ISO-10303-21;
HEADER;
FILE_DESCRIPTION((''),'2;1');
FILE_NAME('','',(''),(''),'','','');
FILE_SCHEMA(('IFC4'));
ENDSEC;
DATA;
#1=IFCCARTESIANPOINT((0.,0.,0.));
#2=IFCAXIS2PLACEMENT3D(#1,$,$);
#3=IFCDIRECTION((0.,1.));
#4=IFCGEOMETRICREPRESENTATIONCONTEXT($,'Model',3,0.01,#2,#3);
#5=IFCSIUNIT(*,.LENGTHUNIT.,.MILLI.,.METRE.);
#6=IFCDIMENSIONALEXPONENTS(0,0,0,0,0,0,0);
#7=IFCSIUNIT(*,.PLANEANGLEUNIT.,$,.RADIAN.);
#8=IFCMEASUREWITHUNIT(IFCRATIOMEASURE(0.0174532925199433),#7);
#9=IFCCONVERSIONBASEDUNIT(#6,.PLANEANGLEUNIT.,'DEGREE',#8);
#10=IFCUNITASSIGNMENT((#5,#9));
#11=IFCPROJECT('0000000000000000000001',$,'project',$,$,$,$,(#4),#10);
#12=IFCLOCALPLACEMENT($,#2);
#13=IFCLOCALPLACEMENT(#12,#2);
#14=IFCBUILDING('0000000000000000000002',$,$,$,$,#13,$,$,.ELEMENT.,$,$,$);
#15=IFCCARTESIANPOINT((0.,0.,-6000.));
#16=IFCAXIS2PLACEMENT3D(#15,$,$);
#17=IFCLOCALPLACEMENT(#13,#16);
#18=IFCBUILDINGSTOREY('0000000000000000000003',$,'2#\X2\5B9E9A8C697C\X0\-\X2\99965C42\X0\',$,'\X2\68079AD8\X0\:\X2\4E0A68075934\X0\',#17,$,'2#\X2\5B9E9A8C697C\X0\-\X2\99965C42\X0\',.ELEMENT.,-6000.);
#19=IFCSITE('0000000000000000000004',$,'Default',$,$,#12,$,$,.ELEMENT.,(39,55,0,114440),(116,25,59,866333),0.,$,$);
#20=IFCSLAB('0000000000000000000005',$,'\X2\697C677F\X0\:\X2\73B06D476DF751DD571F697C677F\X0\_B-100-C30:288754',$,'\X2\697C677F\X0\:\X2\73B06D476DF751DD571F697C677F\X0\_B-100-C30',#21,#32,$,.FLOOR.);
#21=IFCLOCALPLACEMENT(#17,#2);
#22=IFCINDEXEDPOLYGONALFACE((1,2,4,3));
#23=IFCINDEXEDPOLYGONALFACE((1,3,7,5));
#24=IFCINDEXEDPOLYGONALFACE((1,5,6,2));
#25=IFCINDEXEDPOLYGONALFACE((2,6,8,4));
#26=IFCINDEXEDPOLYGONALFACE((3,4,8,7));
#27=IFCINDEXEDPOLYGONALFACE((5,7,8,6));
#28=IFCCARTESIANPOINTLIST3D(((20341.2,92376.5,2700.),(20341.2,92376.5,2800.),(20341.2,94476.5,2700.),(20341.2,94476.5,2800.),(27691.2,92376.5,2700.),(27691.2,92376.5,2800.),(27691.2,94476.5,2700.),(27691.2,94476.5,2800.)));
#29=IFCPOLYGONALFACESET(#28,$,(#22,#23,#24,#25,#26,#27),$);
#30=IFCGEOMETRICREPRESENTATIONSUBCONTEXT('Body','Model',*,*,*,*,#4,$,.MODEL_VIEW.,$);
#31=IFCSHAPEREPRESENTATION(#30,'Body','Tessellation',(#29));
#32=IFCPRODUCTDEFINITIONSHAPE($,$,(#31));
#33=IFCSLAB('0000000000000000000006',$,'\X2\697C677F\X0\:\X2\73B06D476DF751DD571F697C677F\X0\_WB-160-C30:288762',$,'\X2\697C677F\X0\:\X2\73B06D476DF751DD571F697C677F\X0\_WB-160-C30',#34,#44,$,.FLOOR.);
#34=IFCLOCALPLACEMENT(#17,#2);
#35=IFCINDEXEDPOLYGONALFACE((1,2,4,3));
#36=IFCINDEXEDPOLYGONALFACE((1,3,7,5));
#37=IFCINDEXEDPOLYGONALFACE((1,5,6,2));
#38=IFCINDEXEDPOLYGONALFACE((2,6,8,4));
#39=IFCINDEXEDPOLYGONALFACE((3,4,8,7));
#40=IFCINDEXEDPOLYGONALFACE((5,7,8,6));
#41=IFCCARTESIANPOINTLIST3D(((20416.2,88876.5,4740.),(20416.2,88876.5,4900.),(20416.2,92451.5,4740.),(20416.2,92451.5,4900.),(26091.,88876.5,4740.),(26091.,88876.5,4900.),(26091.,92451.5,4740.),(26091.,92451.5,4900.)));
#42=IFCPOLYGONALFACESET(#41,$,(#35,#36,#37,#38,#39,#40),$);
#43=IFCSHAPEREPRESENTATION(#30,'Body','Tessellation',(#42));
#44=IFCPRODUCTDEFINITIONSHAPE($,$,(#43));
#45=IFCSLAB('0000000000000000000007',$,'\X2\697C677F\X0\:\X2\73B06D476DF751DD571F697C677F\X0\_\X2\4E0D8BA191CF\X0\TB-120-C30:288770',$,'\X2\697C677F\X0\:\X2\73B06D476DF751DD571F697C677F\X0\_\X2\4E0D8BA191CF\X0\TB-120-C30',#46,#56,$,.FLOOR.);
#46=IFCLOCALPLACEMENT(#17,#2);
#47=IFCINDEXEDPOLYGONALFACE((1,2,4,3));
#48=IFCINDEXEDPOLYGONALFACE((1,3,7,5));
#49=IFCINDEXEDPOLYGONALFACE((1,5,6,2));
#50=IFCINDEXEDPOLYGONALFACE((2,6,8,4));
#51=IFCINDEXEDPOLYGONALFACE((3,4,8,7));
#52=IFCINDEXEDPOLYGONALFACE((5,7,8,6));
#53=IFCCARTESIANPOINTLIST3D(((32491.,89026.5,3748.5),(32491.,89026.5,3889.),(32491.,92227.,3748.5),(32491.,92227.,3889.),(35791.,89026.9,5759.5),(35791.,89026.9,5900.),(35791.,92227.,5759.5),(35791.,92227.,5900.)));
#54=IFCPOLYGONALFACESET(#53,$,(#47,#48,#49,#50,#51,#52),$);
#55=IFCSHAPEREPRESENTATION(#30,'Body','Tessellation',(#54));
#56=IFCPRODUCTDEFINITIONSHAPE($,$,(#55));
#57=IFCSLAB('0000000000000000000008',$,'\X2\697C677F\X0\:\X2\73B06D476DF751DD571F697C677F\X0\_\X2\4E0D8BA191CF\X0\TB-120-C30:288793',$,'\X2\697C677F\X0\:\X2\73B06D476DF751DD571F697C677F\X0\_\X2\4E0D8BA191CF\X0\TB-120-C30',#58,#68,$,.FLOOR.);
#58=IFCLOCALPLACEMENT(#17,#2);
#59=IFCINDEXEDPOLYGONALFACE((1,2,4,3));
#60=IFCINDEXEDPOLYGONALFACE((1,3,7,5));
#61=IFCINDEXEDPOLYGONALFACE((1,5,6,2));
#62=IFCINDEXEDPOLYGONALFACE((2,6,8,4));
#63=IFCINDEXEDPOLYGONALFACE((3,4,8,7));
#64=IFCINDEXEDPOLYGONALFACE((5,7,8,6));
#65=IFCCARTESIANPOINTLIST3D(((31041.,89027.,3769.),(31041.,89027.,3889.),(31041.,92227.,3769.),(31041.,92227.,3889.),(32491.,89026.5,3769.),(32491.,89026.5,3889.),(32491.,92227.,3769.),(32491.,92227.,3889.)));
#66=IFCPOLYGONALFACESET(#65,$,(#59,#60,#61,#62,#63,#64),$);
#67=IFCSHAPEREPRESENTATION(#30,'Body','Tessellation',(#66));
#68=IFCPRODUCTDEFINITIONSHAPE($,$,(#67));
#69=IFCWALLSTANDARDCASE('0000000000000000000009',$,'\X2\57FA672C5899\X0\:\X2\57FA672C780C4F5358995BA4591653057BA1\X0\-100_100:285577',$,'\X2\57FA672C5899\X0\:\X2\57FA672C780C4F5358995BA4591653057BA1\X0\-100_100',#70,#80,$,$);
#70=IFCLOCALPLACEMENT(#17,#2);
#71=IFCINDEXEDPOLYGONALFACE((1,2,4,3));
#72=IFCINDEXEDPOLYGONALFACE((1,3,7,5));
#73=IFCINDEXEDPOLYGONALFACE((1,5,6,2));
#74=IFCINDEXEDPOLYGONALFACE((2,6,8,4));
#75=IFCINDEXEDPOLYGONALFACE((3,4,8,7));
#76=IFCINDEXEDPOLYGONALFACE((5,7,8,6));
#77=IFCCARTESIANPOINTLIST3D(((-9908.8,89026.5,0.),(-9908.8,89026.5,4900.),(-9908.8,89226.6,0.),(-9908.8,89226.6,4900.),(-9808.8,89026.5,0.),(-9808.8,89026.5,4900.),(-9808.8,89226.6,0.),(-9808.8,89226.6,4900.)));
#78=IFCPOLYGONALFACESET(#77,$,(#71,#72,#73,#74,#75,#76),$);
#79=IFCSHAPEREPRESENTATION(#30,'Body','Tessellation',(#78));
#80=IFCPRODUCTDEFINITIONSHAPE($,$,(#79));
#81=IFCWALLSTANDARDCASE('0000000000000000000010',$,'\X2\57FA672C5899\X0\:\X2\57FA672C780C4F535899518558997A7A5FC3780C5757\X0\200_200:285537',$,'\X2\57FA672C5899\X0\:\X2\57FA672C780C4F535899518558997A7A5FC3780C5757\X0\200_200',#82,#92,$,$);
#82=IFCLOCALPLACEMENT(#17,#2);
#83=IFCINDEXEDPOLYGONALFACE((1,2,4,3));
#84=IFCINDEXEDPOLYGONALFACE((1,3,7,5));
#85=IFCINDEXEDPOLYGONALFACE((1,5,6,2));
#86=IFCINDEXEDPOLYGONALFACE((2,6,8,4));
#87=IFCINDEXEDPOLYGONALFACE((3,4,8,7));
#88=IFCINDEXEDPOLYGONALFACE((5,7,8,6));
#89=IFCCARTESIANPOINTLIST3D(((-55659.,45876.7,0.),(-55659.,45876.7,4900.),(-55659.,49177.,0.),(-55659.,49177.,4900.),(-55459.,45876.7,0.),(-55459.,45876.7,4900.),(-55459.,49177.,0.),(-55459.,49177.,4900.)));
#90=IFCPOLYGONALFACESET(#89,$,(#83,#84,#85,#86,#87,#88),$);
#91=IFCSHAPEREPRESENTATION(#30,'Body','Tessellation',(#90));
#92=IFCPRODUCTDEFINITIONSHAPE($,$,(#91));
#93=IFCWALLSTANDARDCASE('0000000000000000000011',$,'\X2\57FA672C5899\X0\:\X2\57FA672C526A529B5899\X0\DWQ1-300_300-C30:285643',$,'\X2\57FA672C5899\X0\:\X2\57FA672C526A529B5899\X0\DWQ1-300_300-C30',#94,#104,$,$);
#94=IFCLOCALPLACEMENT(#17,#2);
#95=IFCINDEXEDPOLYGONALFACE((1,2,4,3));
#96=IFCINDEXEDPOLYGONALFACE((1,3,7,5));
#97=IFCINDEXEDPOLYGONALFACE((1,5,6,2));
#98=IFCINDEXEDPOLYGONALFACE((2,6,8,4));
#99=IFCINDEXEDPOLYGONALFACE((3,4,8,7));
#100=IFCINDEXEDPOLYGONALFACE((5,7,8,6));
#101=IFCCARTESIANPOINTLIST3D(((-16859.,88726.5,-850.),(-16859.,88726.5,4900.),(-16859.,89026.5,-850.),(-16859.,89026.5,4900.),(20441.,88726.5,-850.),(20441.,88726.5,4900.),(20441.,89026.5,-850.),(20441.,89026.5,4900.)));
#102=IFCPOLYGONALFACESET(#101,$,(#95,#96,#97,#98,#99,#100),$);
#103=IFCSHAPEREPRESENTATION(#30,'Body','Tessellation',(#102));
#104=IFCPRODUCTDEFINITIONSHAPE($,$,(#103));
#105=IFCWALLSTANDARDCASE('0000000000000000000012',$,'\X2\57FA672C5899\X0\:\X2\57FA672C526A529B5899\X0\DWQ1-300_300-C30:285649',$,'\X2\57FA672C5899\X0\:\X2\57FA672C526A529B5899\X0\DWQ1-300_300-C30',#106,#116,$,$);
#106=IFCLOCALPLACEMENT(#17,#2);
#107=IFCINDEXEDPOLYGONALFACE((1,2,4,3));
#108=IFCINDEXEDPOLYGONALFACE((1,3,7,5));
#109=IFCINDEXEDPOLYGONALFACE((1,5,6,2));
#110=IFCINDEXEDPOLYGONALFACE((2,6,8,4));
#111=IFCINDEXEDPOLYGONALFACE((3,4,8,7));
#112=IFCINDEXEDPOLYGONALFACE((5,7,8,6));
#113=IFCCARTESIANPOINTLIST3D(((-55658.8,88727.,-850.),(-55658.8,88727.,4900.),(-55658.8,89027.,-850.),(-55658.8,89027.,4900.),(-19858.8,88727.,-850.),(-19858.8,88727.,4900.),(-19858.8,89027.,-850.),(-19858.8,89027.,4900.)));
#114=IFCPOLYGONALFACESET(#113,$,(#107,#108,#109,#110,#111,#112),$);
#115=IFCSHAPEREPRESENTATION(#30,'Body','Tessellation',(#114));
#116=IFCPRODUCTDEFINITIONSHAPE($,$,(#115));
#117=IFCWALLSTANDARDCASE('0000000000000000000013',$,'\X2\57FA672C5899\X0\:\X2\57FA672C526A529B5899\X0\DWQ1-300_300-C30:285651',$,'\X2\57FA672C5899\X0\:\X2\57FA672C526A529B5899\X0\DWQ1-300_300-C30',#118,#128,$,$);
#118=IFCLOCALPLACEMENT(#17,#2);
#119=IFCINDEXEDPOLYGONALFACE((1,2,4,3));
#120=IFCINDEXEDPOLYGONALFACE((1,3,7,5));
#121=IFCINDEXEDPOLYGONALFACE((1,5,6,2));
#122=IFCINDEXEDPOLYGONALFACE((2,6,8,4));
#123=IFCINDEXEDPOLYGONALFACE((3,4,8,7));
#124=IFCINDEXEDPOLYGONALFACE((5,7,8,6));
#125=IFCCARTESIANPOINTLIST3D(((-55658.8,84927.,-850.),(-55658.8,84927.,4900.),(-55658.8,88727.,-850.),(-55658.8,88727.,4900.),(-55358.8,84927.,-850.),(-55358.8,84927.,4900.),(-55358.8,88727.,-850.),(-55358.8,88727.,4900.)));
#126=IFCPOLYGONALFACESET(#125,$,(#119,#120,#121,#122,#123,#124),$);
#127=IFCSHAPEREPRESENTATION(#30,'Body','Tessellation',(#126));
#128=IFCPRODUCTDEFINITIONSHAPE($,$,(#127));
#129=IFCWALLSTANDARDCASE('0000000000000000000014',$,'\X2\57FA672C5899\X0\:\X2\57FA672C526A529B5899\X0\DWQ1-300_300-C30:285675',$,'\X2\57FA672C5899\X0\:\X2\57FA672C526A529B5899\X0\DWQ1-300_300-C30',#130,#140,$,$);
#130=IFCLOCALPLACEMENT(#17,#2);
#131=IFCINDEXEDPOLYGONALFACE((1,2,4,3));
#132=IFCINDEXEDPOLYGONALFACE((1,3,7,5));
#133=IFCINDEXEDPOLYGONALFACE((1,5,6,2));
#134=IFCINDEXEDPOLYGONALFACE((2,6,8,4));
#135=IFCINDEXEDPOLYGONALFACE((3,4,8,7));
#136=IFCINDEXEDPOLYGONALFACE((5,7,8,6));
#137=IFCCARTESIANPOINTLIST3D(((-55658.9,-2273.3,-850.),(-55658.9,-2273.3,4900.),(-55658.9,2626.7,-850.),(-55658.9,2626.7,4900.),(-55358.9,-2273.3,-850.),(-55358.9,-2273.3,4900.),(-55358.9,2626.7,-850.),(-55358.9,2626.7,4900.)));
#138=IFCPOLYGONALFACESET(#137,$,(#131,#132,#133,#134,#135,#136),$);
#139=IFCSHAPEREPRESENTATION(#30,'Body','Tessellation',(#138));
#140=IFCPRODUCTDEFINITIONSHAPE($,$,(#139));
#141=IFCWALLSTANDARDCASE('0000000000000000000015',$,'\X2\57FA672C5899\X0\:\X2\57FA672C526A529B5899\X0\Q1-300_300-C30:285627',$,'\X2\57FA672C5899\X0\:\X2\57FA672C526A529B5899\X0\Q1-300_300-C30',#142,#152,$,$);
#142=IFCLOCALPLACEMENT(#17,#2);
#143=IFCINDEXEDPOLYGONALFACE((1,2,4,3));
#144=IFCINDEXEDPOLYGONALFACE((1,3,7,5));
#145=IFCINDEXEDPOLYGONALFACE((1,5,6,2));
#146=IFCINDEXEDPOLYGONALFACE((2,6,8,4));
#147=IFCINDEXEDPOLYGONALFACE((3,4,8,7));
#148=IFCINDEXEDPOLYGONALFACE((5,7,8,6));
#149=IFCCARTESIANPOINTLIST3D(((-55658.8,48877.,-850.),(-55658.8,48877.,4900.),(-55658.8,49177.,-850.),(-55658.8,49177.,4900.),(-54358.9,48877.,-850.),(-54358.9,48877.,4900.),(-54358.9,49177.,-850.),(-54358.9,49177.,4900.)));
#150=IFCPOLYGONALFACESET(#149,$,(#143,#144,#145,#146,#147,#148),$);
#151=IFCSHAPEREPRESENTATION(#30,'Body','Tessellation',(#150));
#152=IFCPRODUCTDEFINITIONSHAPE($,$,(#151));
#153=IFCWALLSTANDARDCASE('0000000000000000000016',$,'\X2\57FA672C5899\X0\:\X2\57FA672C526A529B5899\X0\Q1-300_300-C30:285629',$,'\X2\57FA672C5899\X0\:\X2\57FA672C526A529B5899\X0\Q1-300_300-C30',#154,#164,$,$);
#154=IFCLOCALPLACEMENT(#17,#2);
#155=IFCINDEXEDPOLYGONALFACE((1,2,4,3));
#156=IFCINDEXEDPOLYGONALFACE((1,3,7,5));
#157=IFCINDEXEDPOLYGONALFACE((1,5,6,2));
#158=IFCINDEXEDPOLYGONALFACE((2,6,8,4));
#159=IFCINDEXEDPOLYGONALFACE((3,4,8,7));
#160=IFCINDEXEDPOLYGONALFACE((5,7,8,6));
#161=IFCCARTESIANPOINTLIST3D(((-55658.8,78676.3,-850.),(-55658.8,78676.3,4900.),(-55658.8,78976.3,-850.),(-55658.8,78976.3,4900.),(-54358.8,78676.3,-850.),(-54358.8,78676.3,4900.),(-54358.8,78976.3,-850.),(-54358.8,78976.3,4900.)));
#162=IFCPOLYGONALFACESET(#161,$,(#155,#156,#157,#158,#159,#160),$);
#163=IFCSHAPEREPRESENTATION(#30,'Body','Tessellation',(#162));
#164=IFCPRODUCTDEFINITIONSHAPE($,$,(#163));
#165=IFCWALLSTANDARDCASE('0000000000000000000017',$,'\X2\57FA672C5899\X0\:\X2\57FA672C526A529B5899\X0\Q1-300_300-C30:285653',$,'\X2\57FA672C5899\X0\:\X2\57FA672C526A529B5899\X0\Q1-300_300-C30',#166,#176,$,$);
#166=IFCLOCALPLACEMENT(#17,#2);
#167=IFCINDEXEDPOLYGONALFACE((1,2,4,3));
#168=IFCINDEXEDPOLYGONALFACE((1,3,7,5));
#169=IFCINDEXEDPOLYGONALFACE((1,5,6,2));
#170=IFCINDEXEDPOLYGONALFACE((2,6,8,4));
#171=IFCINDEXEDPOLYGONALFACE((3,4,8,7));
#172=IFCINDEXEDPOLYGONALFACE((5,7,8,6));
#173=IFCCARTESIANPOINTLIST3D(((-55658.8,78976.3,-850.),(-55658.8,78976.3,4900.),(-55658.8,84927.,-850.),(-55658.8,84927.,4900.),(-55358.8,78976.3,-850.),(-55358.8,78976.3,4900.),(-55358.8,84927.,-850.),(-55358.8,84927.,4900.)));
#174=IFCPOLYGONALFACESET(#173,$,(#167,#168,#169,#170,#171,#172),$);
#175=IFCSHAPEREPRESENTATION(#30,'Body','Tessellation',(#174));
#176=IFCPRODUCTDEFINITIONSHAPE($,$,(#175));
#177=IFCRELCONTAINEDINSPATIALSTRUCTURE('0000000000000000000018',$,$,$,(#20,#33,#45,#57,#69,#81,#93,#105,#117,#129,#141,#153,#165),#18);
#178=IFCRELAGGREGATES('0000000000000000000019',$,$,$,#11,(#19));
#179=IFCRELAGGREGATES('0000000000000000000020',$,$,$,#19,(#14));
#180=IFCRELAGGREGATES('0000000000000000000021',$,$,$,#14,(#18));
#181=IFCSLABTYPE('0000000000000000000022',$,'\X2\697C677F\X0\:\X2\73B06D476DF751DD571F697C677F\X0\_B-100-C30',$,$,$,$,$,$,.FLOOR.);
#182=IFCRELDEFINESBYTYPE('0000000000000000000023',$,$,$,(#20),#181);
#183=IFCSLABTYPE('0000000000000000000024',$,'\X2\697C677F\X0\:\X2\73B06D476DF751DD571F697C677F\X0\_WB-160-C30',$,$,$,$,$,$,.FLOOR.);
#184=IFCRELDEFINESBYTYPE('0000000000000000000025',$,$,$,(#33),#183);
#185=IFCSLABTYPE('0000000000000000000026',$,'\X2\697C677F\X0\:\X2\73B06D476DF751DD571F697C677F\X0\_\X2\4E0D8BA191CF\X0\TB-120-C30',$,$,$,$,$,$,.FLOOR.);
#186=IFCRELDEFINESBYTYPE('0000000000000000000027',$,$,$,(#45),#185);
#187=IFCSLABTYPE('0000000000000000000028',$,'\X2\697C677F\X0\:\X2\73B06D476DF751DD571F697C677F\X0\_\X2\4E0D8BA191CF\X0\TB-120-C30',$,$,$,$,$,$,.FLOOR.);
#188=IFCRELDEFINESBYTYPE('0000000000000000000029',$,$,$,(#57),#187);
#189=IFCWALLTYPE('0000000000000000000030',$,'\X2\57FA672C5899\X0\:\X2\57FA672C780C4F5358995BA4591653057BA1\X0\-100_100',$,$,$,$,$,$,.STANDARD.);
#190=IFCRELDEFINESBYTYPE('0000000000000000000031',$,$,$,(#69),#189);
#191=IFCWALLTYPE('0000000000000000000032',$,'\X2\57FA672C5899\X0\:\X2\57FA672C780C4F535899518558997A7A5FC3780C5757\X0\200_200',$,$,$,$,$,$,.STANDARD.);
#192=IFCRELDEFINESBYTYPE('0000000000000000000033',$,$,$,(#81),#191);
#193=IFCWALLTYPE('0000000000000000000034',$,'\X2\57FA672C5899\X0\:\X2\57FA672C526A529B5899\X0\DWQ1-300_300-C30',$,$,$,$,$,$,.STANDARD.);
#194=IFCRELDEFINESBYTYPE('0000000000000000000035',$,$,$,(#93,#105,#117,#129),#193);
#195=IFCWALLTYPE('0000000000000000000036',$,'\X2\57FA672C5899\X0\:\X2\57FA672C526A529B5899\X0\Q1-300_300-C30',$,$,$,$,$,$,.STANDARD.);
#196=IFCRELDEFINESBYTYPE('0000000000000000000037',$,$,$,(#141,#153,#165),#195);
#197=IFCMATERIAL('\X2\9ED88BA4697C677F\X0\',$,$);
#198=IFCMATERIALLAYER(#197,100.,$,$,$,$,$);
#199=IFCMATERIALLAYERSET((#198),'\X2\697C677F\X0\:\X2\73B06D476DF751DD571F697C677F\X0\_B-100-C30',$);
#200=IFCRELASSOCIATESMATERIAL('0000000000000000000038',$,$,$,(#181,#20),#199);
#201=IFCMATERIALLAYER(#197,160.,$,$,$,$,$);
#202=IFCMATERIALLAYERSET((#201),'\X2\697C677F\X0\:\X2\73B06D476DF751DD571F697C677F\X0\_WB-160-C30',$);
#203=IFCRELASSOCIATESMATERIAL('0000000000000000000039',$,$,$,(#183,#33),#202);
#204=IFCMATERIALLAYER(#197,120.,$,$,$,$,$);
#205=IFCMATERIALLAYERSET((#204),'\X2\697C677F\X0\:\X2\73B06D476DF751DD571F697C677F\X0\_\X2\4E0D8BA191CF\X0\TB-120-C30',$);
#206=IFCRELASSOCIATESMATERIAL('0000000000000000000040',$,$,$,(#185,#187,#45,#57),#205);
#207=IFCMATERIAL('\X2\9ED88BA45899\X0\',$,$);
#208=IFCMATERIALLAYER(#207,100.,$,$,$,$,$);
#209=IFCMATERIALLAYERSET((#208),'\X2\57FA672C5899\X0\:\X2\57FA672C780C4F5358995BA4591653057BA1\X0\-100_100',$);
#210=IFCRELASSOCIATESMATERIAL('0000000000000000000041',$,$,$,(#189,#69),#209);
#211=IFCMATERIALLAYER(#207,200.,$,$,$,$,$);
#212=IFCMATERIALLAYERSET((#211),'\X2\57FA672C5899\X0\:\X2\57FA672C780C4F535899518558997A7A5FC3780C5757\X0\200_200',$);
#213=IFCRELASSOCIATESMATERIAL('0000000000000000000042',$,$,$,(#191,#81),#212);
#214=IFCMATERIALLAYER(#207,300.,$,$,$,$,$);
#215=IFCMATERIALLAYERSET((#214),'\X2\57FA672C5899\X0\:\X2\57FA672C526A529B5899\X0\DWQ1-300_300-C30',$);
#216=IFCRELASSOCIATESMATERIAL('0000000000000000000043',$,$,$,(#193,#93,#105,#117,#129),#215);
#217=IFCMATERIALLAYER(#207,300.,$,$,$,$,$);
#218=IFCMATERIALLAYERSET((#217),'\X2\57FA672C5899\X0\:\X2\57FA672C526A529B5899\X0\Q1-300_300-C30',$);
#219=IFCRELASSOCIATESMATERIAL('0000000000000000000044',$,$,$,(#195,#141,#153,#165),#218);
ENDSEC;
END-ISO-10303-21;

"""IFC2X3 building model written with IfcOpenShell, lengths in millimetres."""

from ifc_helpers import new_model, entity, si_unit, converted_unit, direction, frame, frame_2d, origin, place, context, subcontext, project, spatial, polyline, rectangle, outline, extrude, clip, halfspace, material, layer, layer_set, layer_usage, type_object, element, save


model = new_model("IFC2X3")

# Units and contexts
model_context = context("Model", 3, precision=0.01, world=origin(), true_north=direction((0.0, 1.0)))
body_context = subcontext(model_context, "Body", "Model", "MODEL_VIEW")
ifc_project = project(units=[si_unit("LENGTHUNIT", "METRE", prefix="MILLI"), converted_unit("PLANEANGLEUNIT", "DEGREE", entity("IfcRatioMeasure", 0.0174532925199433), si_unit("PLANEANGLEUNIT", "RADIAN"), dimensions=[0, 0, 0, 0, 0, 0, 0])], contexts=[model_context])

# Site, building, storey
site_placement = place(None, origin())
site = spatial("IfcSite", under=ifc_project, at=site_placement, Name="Default", CompositionType="ELEMENT", RefLatitude=(39, 55, 0, 114440), RefLongitude=(116, 25, 59, 866333), RefElevation=0.0)
building_placement = place(site_placement, origin())
building = spatial("IfcBuilding", under=site, at=building_placement, CompositionType="ELEMENT")
storey_placement = place(building_placement, frame((0.0, 0.0, -6000.0)))
storey = spatial("IfcBuildingStorey", under=building, at=storey_placement, Name="2#实验楼-首层", ObjectType="标高:上标头", LongName="2#实验楼-首层", CompositionType="ELEMENT", Elevation=-6000.0)

# Slabs
ifc_material_1 = material(Name="默认楼板")
ifc_layer_1 = layer(ifc_material_1, 100.0)
ifc_layer_set_1 = layer_set([ifc_layer_1], Name="楼板:现浇混凝土楼板_B-100-C30")
ifc_layer_usage_1 = layer_usage(ifc_layer_set_1, "AXIS3", "POSITIVE", 0.0)
slab_type_1 = type_object("IfcSlabType", Name="楼板:现浇混凝土楼板_B-100-C30", PredefinedType="FLOOR", material=ifc_layer_set_1)
slab_1_placement = place(storey_placement, origin())
element("IfcSlab", 1, at=slab_1_placement, inside=storey, type_object=slab_type_1, material=ifc_layer_usage_1, Name="楼板:现浇混凝土楼板_B-100-C30:288754", ObjectType="楼板:现浇混凝土楼板_B-100-C30", PredefinedType="FLOOR", context=body_context, shape_type="SweptSolid", body=[
    extrude(outline(polyline([(-3675.0, -1050.0), (3675.0, -1050.0), (3675.0, 1050.0), (-3675.0, 1050.0), (-3675.0, -1050.0)])), frame((24016.2, 93426.5, 2800.0), z_axis=(0.0, 0.0, -1.0), x_axis=(1.0, -0.000002, 0.0)), (0.0, 0.0, 1.0), 100.0),
])
ifc_layer_2 = layer(ifc_material_1, 160.0)
ifc_layer_set_2 = layer_set([ifc_layer_2], Name="楼板:现浇混凝土楼板_WB-160-C30")
ifc_layer_usage_2 = layer_usage(ifc_layer_set_2, "AXIS3", "POSITIVE", 0.0)
slab_type_2 = type_object("IfcSlabType", Name="楼板:现浇混凝土楼板_WB-160-C30", PredefinedType="FLOOR", material=ifc_layer_set_2)
slab_2_placement = place(storey_placement, origin())
element("IfcSlab", 2, at=slab_2_placement, inside=storey, type_object=slab_type_2, material=ifc_layer_usage_2, Name="楼板:现浇混凝土楼板_WB-160-C30:288762", ObjectType="楼板:现浇混凝土楼板_WB-160-C30", PredefinedType="FLOOR", context=body_context, shape_type="SweptSolid", body=[
    extrude(outline(polyline([(-1787.5, -2837.4), (1787.5, -2837.4), (1787.5, 2837.4), (-1787.5, 2837.4), (-1787.5, -2837.4)])), frame((23253.6, 90664.0, 4900.0), z_axis=(0.0, 0.0, -1.0), x_axis=(0.0, -1.0, 0.0)), (0.0, 0.0, 1.0), 160.0),
])
ifc_layer_3 = layer(ifc_material_1, 120.0)
ifc_layer_set_3 = layer_set([ifc_layer_3], Name="楼板:现浇混凝土楼板_不计量TB-120-C30")
ifc_layer_usage_3 = layer_usage(ifc_layer_set_3, "AXIS3", "POSITIVE", 0.0)
slab_type_3 = type_object("IfcSlabType", Name="楼板:现浇混凝土楼板_不计量TB-120-C30", PredefinedType="FLOOR", material=ifc_layer_set_3)
slab_3_placement = place(storey_placement, origin())
element("IfcSlab", 3, at=slab_3_placement, inside=storey, type_object=slab_type_3, material=ifc_layer_usage_3, Name="楼板:现浇混凝土楼板_不计量TB-120-C30:288770", ObjectType="楼板:现浇混凝土楼板_不计量TB-120-C30", PredefinedType="FLOOR", context=body_context, shape_type="Clipping", body=[
    clip(clip(extrude(outline(polyline([(-1600.3, -1932.2), (1600.1, -1932.2), (1600.1, 1932.2), (-1599.9, 1932.2), (-1600.3, -1932.2)])), frame((34141.0, 90626.9, 4894.5), z_axis=(0.520382, 0.0, -0.853934), x_axis=(0.0, 1.0, 0.0)), (0.0, -0.520382, 0.853934), 164.6), halfspace(frame((32491.0, 92227.0, 3748.5), z_axis=(0.520382, 0.0, -0.853934), x_axis=(0.853934, 0.0, 0.520382)), False)), halfspace(frame((32491.0, 92227.0, 3889.0), z_axis=(-0.520382, 0.0, 0.853934), x_axis=(-0.853934, 0.0, -0.520382)), False)),
])
ifc_layer_usage_4 = layer_usage(ifc_layer_set_3, "AXIS3", "POSITIVE", 0.0)
slab_type_4 = type_object("IfcSlabType", Name="楼板:现浇混凝土楼板_不计量TB-120-C30", PredefinedType="FLOOR", material=ifc_layer_set_3)
slab_4_placement = place(storey_placement, origin())
element("IfcSlab", 4, at=slab_4_placement, inside=storey, type_object=slab_type_4, material=ifc_layer_usage_4, Name="楼板:现浇混凝土楼板_不计量TB-120-C30:288793", ObjectType="楼板:现浇混凝土楼板_不计量TB-120-C30", PredefinedType="FLOOR", context=body_context, shape_type="SweptSolid", body=[
    extrude(outline(polyline([(-1599.9, -725.0), (1600.1, -725.0), (1600.1, 725.0), (-1600.3, 725.0), (-1599.9, -725.0)])), frame((31766.0, 90626.9, 3889.0), z_axis=(0.0, 0.0, -1.0), x_axis=(0.0, 1.0, 0.0)), (0.0, 0.0, 1.0), 120.0),
])

# Walls
ifc_material_2 = material(Name="默认墙")
ifc_layer_4 = layer(ifc_material_2, 100.0)
ifc_layer_set_4 = layer_set([ifc_layer_4], Name="基本墙:基本砌体墙室外包管-100_100")
ifc_layer_usage_5 = layer_usage(ifc_layer_set_4, "AXIS2", "NEGATIVE", 50.0)
wall_type_1 = type_object("IfcWallType", Name="基本墙:基本砌体墙室外包管-100_100", PredefinedType="STANDARD", material=ifc_layer_set_4)
wall_1_placement = place(storey_placement, frame((-9858.8, 89026.5, 0.0), z_axis=(0.0, 0.0, 1.0), x_axis=(0.0, 1.0, 0.0)))
element("IfcWallStandardCase", 5, at=wall_1_placement, inside=storey, type_object=wall_type_1, material=ifc_layer_usage_5, Name="基本墙:基本砌体墙室外包管-100_100:285577", ObjectType="基本墙:基本砌体墙室外包管-100_100", context=body_context, shape_type="SweptSolid", body=[
    extrude(rectangle(XDim=200.0, YDim=100.0, at=frame_2d((100.0, 0.0), x_axis=(-1.0, 0.0))), origin(), (0.0, 0.0, 1.0), 4900.0),
])
ifc_layer_5 = layer(ifc_material_2, 200.0)
ifc_layer_set_5 = layer_set([ifc_layer_5], Name="基本墙:基本砌体墙内墙空心砌块200_200")
ifc_layer_usage_6 = layer_usage(ifc_layer_set_5, "AXIS2", "NEGATIVE", 100.0)
wall_type_2 = type_object("IfcWallType", Name="基本墙:基本砌体墙内墙空心砌块200_200", PredefinedType="STANDARD", material=ifc_layer_set_5)
wall_2_placement = place(storey_placement, frame((-55559.0, 45876.7, 0.0), z_axis=(0.0, 0.0, 1.0), x_axis=(0.0, 1.0, 0.0)))
element("IfcWallStandardCase", 6, at=wall_2_placement, inside=storey, type_object=wall_type_2, material=ifc_layer_usage_6, Name="基本墙:基本砌体墙内墙空心砌块200_200:285537", ObjectType="基本墙:基本砌体墙内墙空心砌块200_200", context=body_context, shape_type="SweptSolid", body=[
    extrude(rectangle(XDim=3300.3, YDim=200.0, at=frame_2d((1650.2, 0.0), x_axis=(-1.0, 0.0))), origin(), (0.0, 0.0, 1.0), 4900.0),
])
ifc_layer_6 = layer(ifc_material_2, 300.0)
ifc_layer_set_6 = layer_set([ifc_layer_6], Name="基本墙:基本剪力墙DWQ1-300_300-C30")
ifc_layer_usage_7 = layer_usage(ifc_layer_set_6, "AXIS2", "NEGATIVE", 150.0)
wall_type_3 = type_object("IfcWallType", Name="基本墙:基本剪力墙DWQ1-300_300-C30", PredefinedType="STANDARD", material=ifc_layer_set_6)
wall_3_placement = place(storey_placement, frame((-16859.0, 88876.5, -850.0)))
element("IfcWallStandardCase", 7, at=wall_3_placement, inside=storey, type_object=wall_type_3, material=ifc_layer_usage_7, Name="基本墙:基本剪力墙DWQ1-300_300-C30:285643", ObjectType="基本墙:基本剪力墙DWQ1-300_300-C30", context=body_context, shape_type="SweptSolid", body=[
    extrude(rectangle(XDim=37300.0, YDim=300.0, at=frame_2d((18650.0, 0.0), x_axis=(-1.0, 0.0))), origin(), (0.0, 0.0, 1.0), 5750.0),
])
ifc_layer_usage_8 = layer_usage(ifc_layer_set_6, "AXIS2", "NEGATIVE", 150.0)
wall_4_placement = place(storey_placement, frame((-55658.8, 88877.0, -850.0)))
element("IfcWallStandardCase", 8, at=wall_4_placement, inside=storey, type_object=wall_type_3, material=ifc_layer_usage_8, Name="基本墙:基本剪力墙DWQ1-300_300-C30:285649", ObjectType="基本墙:基本剪力墙DWQ1-300_300-C30", context=body_context, shape_type="SweptSolid", body=[
    extrude(rectangle(XDim=35800.0, YDim=300.0, at=frame_2d((17900.0, 0.0), x_axis=(-1.0, 0.0))), origin(), (0.0, 0.0, 1.0), 5750.0),
])
ifc_layer_usage_9 = layer_usage(ifc_layer_set_6, "AXIS2", "NEGATIVE", 150.0)
wall_5_placement = place(storey_placement, frame((-55508.8, 84927.0, -850.0), z_axis=(0.0, 0.0, 1.0), x_axis=(0.0, 1.0, 0.0)))
element("IfcWallStandardCase", 9, at=wall_5_placement, inside=storey, type_object=wall_type_3, material=ifc_layer_usage_9, Name="基本墙:基本剪力墙DWQ1-300_300-C30:285651", ObjectType="基本墙:基本剪力墙DWQ1-300_300-C30", context=body_context, shape_type="SweptSolid", body=[
    extrude(rectangle(XDim=3800.0, YDim=300.0, at=frame_2d((1900.0, 0.0), x_axis=(-1.0, 0.0))), origin(), (0.0, 0.0, 1.0), 5750.0),
])
ifc_layer_usage_10 = layer_usage(ifc_layer_set_6, "AXIS2", "NEGATIVE", 150.0)
wall_6_placement = place(storey_placement, frame((-55508.9, -2273.3, -850.0), z_axis=(0.0, 0.0, 1.0), x_axis=(0.0, 1.0, 0.0)))
element("IfcWallStandardCase", 10, at=wall_6_placement, inside=storey, type_object=wall_type_3, material=ifc_layer_usage_10, Name="基本墙:基本剪力墙DWQ1-300_300-C30:285675", ObjectType="基本墙:基本剪力墙DWQ1-300_300-C30", context=body_context, shape_type="SweptSolid", body=[
    extrude(rectangle(XDim=4900.0, YDim=300.0, at=frame_2d((2450.0, 0.0), x_axis=(-1.0, 0.0))), origin(), (0.0, 0.0, 1.0), 5750.0),
])
ifc_layer_7 = layer(ifc_material_2, 300.0)
ifc_layer_set_7 = layer_set([ifc_layer_7], Name="基本墙:基本剪力墙Q1-300_300-C30")
ifc_layer_usage_11 = layer_usage(ifc_layer_set_7, "AXIS2", "NEGATIVE", 150.0)
wall_type_4 = type_object("IfcWallType", Name="基本墙:基本剪力墙Q1-300_300-C30", PredefinedType="STANDARD", material=ifc_layer_set_7)
wall_7_placement = place(storey_placement, frame((-54358.9, 49027.0, -850.0), z_axis=(0.0, 0.0, 1.0), x_axis=(-1.0, 0.0, 0.0)))
element("IfcWallStandardCase", 11, at=wall_7_placement, inside=storey, type_object=wall_type_4, material=ifc_layer_usage_11, Name="基本墙:基本剪力墙Q1-300_300-C30:285627", ObjectType="基本墙:基本剪力墙Q1-300_300-C30", context=body_context, shape_type="SweptSolid", body=[
    extrude(rectangle(XDim=1299.9, YDim=300.0, at=frame_2d((650.0, 0.0), x_axis=(-1.0, 0.0))), origin(), (0.0, 0.0, 1.0), 5750.0),
])
ifc_layer_usage_12 = layer_usage(ifc_layer_set_7, "AXIS2", "NEGATIVE", 150.0)
wall_8_placement = place(storey_placement, frame((-54358.8, 78826.3, -850.0), z_axis=(0.0, 0.0, 1.0), x_axis=(-1.0, 0.0, 0.0)))
element("IfcWallStandardCase", 12, at=wall_8_placement, inside=storey, type_object=wall_type_4, material=ifc_layer_usage_12, Name="基本墙:基本剪力墙Q1-300_300-C30:285629", ObjectType="基本墙:基本剪力墙Q1-300_300-C30", context=body_context, shape_type="SweptSolid", body=[
    extrude(rectangle(XDim=1300.0, YDim=300.0, at=frame_2d((650.0, 0.0), x_axis=(-1.0, 0.0))), origin(), (0.0, 0.0, 1.0), 5750.0),
])
ifc_layer_usage_13 = layer_usage(ifc_layer_set_7, "AXIS2", "NEGATIVE", 150.0)
wall_9_placement = place(storey_placement, frame((-55508.8, 78976.3, -850.0), z_axis=(0.0, 0.0, 1.0), x_axis=(0.0, 1.0, 0.0)))
element("IfcWallStandardCase", 13, at=wall_9_placement, inside=storey, type_object=wall_type_4, material=ifc_layer_usage_13, Name="基本墙:基本剪力墙Q1-300_300-C30:285653", ObjectType="基本墙:基本剪力墙Q1-300_300-C30", context=body_context, shape_type="SweptSolid", body=[
    extrude(rectangle(XDim=5950.7, YDim=300.0, at=frame_2d((2975.3, 0.0), x_axis=(-1.0, 0.0))), origin(), (0.0, 0.0, 1.0), 5750.0),
])

save(model, "model.ifc")
